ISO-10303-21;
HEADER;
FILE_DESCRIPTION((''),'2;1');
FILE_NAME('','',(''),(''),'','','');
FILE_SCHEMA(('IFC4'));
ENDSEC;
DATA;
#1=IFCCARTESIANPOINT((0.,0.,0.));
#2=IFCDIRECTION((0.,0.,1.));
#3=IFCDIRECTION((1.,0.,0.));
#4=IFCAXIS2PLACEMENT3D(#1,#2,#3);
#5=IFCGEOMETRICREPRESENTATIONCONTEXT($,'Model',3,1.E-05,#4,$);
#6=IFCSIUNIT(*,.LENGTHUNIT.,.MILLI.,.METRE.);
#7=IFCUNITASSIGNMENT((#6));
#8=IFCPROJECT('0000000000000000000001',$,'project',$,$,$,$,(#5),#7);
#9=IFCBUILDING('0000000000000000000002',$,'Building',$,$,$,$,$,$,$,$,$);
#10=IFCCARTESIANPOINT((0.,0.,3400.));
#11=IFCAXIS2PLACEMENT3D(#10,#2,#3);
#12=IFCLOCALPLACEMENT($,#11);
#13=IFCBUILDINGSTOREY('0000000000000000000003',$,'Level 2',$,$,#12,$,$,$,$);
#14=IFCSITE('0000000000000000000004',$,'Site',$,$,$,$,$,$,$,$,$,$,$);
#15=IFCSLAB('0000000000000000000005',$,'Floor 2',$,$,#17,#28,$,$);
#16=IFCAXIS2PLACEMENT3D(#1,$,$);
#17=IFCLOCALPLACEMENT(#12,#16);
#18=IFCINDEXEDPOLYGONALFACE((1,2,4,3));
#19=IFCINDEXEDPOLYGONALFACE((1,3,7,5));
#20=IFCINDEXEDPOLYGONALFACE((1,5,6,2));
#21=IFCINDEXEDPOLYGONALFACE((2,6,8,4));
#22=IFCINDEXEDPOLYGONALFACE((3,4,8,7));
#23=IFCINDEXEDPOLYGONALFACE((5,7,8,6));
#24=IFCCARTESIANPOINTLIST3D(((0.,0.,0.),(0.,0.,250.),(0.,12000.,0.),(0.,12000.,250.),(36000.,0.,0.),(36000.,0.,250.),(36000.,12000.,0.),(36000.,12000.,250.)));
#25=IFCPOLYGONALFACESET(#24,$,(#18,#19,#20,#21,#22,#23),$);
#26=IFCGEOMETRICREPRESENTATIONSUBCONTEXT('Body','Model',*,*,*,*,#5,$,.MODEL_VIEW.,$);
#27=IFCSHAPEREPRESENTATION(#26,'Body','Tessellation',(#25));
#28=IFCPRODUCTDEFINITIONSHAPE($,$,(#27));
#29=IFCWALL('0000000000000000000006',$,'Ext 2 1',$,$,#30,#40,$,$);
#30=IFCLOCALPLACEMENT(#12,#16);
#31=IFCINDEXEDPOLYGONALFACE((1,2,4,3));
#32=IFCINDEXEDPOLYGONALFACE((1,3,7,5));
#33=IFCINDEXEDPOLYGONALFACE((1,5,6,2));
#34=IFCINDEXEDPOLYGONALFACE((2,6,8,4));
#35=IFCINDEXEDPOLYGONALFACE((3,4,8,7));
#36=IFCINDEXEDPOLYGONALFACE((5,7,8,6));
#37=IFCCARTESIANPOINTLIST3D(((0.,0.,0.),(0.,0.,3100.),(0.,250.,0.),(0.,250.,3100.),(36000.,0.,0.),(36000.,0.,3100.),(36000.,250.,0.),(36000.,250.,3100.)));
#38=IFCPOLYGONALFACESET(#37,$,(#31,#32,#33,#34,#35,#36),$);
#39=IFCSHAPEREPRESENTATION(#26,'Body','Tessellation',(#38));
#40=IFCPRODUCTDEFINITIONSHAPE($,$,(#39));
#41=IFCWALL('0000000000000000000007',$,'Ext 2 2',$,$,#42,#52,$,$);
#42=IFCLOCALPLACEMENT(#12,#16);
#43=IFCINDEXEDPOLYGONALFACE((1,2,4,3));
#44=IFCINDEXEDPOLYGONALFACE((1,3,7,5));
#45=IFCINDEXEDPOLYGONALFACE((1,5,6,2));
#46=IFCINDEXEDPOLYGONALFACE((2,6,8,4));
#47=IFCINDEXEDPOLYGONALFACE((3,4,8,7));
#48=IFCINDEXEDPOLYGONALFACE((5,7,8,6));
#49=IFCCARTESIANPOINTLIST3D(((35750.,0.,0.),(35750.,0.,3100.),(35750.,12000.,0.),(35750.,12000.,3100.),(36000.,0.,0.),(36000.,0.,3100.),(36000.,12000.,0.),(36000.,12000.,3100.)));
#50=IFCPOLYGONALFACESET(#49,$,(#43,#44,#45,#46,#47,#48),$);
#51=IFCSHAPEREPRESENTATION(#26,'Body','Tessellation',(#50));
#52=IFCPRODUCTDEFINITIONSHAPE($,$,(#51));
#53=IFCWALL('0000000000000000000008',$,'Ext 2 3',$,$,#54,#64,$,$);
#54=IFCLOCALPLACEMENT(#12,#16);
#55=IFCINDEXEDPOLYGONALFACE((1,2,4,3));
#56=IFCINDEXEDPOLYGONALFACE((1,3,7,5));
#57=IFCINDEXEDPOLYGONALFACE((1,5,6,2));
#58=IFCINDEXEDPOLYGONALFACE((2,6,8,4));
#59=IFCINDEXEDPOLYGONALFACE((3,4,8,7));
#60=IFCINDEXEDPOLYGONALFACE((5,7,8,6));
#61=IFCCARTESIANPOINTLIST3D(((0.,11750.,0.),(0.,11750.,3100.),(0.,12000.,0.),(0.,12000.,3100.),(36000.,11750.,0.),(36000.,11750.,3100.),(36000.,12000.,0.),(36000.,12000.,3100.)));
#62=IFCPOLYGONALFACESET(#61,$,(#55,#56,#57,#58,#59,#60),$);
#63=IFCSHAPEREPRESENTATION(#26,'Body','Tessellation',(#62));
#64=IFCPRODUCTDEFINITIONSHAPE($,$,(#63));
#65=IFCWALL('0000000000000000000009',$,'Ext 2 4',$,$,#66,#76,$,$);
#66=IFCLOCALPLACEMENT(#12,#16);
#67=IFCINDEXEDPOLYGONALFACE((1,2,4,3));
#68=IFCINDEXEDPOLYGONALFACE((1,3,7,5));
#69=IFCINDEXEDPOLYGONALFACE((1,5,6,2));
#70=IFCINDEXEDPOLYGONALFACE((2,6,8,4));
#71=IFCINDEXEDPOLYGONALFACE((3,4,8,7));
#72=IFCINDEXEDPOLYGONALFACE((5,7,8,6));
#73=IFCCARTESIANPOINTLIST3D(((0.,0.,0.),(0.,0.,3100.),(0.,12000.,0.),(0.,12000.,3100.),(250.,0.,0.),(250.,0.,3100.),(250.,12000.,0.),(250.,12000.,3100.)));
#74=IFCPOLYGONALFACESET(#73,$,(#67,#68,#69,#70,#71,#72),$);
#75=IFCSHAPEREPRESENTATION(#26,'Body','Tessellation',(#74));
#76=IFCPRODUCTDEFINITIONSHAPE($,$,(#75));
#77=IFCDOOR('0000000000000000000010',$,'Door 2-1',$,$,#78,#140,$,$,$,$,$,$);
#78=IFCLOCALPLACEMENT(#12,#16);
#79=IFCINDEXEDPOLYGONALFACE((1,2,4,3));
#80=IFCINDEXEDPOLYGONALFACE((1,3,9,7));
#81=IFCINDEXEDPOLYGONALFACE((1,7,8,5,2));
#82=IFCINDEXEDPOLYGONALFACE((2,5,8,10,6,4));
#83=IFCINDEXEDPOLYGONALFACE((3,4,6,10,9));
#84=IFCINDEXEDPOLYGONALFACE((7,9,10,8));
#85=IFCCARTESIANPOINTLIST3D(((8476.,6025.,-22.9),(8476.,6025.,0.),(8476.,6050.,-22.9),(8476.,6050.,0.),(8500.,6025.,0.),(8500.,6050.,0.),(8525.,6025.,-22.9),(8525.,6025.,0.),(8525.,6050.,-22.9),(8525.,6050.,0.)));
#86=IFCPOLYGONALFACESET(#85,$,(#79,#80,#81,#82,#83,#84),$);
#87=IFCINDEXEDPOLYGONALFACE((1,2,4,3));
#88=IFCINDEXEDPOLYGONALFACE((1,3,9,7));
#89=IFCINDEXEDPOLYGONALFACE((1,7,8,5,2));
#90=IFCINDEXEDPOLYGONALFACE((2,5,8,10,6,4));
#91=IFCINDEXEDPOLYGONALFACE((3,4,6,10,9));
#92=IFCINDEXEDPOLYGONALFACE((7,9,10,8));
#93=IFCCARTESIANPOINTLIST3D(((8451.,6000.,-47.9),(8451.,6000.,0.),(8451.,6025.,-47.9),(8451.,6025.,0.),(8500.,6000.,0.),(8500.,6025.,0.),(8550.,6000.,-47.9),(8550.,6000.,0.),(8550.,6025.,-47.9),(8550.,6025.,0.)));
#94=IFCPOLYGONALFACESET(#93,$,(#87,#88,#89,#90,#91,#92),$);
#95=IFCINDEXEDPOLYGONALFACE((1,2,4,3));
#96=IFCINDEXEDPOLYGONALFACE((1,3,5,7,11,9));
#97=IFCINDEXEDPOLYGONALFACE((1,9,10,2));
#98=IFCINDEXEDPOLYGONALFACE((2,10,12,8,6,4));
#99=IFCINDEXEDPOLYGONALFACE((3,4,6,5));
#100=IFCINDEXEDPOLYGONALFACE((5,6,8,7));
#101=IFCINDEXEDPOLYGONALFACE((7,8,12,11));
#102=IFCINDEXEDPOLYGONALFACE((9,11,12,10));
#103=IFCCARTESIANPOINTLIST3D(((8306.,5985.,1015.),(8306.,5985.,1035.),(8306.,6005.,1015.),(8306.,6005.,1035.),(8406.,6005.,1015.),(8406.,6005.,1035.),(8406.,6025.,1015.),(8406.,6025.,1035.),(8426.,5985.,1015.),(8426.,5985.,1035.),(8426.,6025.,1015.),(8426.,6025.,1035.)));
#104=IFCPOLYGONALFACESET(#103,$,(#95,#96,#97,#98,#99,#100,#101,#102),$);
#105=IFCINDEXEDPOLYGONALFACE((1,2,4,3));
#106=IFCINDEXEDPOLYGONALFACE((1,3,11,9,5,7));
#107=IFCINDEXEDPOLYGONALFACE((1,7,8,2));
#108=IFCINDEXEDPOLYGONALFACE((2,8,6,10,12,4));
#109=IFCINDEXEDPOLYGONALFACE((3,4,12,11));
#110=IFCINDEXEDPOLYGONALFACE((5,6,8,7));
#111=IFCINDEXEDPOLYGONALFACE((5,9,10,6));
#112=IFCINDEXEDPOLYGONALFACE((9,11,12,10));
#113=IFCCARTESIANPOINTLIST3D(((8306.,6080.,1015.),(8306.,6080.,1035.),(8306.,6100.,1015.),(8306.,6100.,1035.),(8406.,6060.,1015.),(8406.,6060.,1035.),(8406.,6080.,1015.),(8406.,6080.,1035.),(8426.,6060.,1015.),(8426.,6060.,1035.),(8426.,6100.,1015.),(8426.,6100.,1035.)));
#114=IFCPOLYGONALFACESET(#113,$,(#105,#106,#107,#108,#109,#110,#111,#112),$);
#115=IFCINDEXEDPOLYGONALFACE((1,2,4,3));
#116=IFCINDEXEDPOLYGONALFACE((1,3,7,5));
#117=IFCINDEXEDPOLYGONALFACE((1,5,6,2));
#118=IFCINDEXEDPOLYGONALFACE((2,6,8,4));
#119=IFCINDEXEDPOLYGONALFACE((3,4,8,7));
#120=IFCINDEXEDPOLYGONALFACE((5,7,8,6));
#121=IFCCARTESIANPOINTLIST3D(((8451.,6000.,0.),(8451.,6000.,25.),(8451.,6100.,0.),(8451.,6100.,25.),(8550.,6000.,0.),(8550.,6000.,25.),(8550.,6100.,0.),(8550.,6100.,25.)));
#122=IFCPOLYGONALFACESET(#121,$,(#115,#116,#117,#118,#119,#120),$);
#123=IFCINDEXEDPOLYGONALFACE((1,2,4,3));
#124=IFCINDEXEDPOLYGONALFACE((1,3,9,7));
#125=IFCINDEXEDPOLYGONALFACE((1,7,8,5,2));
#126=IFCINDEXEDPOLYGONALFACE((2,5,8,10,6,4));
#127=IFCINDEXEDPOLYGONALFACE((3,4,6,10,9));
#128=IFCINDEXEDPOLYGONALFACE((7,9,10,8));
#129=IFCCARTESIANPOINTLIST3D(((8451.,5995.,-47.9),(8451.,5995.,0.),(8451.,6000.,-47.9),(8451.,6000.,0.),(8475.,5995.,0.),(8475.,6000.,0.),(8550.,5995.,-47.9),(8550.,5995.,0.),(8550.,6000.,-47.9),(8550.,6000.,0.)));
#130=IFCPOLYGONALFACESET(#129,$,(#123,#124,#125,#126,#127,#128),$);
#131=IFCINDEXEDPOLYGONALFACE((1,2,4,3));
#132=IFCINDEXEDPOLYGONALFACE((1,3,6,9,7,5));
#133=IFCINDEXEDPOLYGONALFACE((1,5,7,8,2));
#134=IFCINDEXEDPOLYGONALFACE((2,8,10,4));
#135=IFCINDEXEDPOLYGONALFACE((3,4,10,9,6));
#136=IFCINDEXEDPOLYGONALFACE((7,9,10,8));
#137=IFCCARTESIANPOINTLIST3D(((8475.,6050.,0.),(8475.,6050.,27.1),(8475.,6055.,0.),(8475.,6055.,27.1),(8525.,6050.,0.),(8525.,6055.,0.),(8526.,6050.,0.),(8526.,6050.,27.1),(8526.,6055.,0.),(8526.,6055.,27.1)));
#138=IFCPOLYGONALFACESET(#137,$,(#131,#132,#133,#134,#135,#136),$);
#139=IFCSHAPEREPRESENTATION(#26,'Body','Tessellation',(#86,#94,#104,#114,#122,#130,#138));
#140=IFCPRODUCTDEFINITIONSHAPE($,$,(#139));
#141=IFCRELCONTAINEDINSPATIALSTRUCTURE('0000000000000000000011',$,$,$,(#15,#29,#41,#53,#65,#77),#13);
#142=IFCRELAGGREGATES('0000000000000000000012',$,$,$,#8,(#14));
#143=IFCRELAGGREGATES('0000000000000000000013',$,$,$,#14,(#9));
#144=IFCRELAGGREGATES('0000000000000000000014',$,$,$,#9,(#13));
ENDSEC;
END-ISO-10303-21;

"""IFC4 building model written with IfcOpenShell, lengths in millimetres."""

from ifc_helpers import new_model, si_unit, frame, origin_with_axes, place, context, subcontext, project, spatial, line, indexed_curve, outline, extrude, element, save


model = new_model("IFC4")

# Units and contexts
model_context = context("Model", 3, precision=1e-05, world=origin_with_axes())
body_context = subcontext(model_context, "Body", "Model", "MODEL_VIEW")
ifc_project = project(units=[si_unit("LENGTHUNIT", "METRE", prefix="MILLI")], contexts=[model_context])

# Site, building, storey
site = spatial("IfcSite", under=ifc_project, Name="Site")
building = spatial("IfcBuilding", under=site, Name="Building")
storey_placement = place(None, frame((0.0, 0.0, 3400.0), z_axis=(0.0, 0.0, 1.0), x_axis=(1.0, 0.0, 0.0)))
storey = spatial("IfcBuildingStorey", under=building, at=storey_placement, Name="Level 2")

# Slab
slab_placement = place(storey_placement, origin_with_axes())
element("IfcSlab", 1, at=slab_placement, inside=storey, Name="Floor 2", context=body_context, shape_type="SweptSolid", body=[
    extrude(outline(indexed_curve([(0.0, 0.0), (36000.0, 0.0), (36000.0, 12000.0), (0.0, 12000.0), (0.0, 0.0)])), None, (0.0, 0.0, 1.0), 250.0),
])

# Walls
wall_1_placement = place(storey_placement, origin_with_axes())
element("IfcWall", 2, at=wall_1_placement, inside=storey, Name="Ext 2 1", context=body_context, shape_type="SweptSolid", body=[
    extrude(outline(indexed_curve([(0.0, 0.0), (0.0, 250.0), (36000.0, 250.0), (36000.0, 0.0), (0.0, 0.0)], self_intersect=False)), origin_with_axes(), (0.0, 0.0, 1.0), 3100.0),
])
wall_2_placement = place(storey_placement, frame((36000.0, 0.0, 0.0), z_axis=(0.0, 0.0, 1.0), x_axis=(0.0, 1.0, 0.0)))
element("IfcWall", 3, at=wall_2_placement, inside=storey, Name="Ext 2 2", context=body_context, shape_type="SweptSolid", body=[
    extrude(outline(indexed_curve([(0.0, 0.0), (0.0, 250.0), (12000.0, 250.0), (12000.0, 0.0), (0.0, 0.0)], self_intersect=False)), origin_with_axes(), (0.0, 0.0, 1.0), 3100.0),
])
wall_3_placement = place(storey_placement, frame((36000.0, 12000.0, 0.0), z_axis=(0.0, 0.0, 1.0), x_axis=(-1.0, 0.0, 0.0)))
element("IfcWall", 4, at=wall_3_placement, inside=storey, Name="Ext 2 3", context=body_context, shape_type="SweptSolid", body=[
    extrude(outline(indexed_curve([(0.0, 0.0), (0.0, 250.0), (36000.0, 250.0), (36000.0, 0.0), (0.0, 0.0)], self_intersect=False)), origin_with_axes(), (0.0, 0.0, 1.0), 3100.0),
])
wall_4_placement = place(storey_placement, frame((0.0, 12000.0, 0.0), z_axis=(0.0, 0.0, 1.0), x_axis=(0.0, -1.0, 0.0)))
element("IfcWall", 5, at=wall_4_placement, inside=storey, Name="Ext 2 4", context=body_context, shape_type="SweptSolid", body=[
    extrude(outline(indexed_curve([(0.0, 0.0), (0.0, 250.0), (12000.0, 250.0), (12000.0, 0.0), (0.0, 0.0)], self_intersect=False)), origin_with_axes(), (0.0, 0.0, 1.0), 3100.0),
])

# Door
door_1_placement = place(storey_placement, frame((8500.0, 6000.0, 0.0), z_axis=(0.0, 0.0, 1.0), x_axis=(1.0, 0.0, 0.0)))
element("IfcDoor", 6, at=door_1_placement, inside=storey, Name="Door 2-1", context=body_context, shape_type="SweptSolid", body=[
    extrude(outline(indexed_curve([(0.0, 0.0), (0.0, 2.1), (1.0, 2.1), (1.0, 0.0), (-24.0, 0.0), (-24.0, -22.9), (25.0, -22.9), (25.0, 0.0)], segments=[line(1, 2, 3, 4, 5, 6, 7, 8, 1)])), frame((0.0, 25.0, 0.0), z_axis=(0.0, -1.0, 0.0), x_axis=(1.0, 0.0, 0.0)), (0.0, 0.0, -1.0), 25.0),
    extrude(outline(indexed_curve([(0.0, 0.0), (0.0, 2.1), (1.0, 2.1), (1.0, 0.0), (-49.0, 0.0), (-49.0, -47.9), (50.0, -47.9), (50.0, 0.0)], segments=[line(1, 2, 3, 4, 5, 6, 7, 8, 1)])), frame((0.0, 0.0, 0.0), z_axis=(0.0, -1.0, 0.0), x_axis=(1.0, 0.0, 0.0)), (0.0, 0.0, -1.0), 25.0),
    extrude(outline(indexed_curve([(0.0, 0.0), (-49.0, 0.0), (-49.0, 35.0), (0.0, 35.0)], segments=[line(1, 2, 3, 4, 1)])), frame((25.0, 25.0, 25.0), z_axis=(0.0, 0.0, 1.0), x_axis=(1.0, 0.0, 0.0)), (0.0, 0.0, 1.0), -47.9),
    extrude(outline(indexed_curve([(0.0, 0.0), (0.0, -40.0), (-120.0, -40.0), (-120.0, -20.0), (-20.0, -20.0), (-20.0, 0.0)], segments=[line(1, 2, 3, 4, 5, 6, 1)])), frame((-74.0, 25.0, 1015.0), z_axis=(0.0, 0.0, 1.0), x_axis=(1.0, 0.0, 0.0)), (0.0, 0.0, 1.0), 20.0),
    extrude(outline(indexed_curve([(0.0, 0.0), (0.0, 40.0), (-120.0, 40.0), (-120.0, 20.0), (-20.0, 20.0), (-20.0, 0.0)], segments=[line(1, 2, 3, 4, 5, 6, 1)])), frame((-74.0, 60.0, 1015.0), z_axis=(0.0, 0.0, 1.0), x_axis=(1.0, 0.0, 0.0)), (0.0, 0.0, 1.0), 20.0),
    extrude(outline(indexed_curve([(0.0, 0.0), (-99.0, 0.0), (-99.0, 100.0), (0.0, 100.0)], segments=[line(1, 2, 3, 4, 1)])), frame((50.0, 0.0, 0.0), z_axis=(0.0, 0.0, 1.0), x_axis=(1.0, 0.0, 0.0)), (0.0, 0.0, 1.0), 25.0),
    extrude(outline(indexed_curve([(0.0, 0.0), (0.0, 27.1), (51.0, 27.1), (51.0, 0.0), (-24.0, 0.0), (-24.0, -47.9), (75.0, -47.9), (75.0, 0.0)], segments=[line(1, 2, 3, 4, 5, 6, 7, 8, 1)])), frame((-25.0, -5.0, 0.0), z_axis=(0.0, -1.0, 0.0), x_axis=(1.0, 0.0, 0.0)), (0.0, 0.0, -1.0), 5.0),
    extrude(outline(indexed_curve([(0.0, 0.0), (0.0, 27.1), (51.0, 27.1), (51.0, 0.0), (1.0, 0.0), (1.0, -22.9), (50.0, -22.9), (50.0, 0.0)], segments=[line(1, 2, 3, 4, 5, 6, 7, 8, 1)])), frame((-25.0, 50.0, 0.0), z_axis=(0.0, -1.0, 0.0), x_axis=(1.0, 0.0, 0.0)), (0.0, 0.0, -1.0), 5.0),
])

save(model, "model.ifc")
